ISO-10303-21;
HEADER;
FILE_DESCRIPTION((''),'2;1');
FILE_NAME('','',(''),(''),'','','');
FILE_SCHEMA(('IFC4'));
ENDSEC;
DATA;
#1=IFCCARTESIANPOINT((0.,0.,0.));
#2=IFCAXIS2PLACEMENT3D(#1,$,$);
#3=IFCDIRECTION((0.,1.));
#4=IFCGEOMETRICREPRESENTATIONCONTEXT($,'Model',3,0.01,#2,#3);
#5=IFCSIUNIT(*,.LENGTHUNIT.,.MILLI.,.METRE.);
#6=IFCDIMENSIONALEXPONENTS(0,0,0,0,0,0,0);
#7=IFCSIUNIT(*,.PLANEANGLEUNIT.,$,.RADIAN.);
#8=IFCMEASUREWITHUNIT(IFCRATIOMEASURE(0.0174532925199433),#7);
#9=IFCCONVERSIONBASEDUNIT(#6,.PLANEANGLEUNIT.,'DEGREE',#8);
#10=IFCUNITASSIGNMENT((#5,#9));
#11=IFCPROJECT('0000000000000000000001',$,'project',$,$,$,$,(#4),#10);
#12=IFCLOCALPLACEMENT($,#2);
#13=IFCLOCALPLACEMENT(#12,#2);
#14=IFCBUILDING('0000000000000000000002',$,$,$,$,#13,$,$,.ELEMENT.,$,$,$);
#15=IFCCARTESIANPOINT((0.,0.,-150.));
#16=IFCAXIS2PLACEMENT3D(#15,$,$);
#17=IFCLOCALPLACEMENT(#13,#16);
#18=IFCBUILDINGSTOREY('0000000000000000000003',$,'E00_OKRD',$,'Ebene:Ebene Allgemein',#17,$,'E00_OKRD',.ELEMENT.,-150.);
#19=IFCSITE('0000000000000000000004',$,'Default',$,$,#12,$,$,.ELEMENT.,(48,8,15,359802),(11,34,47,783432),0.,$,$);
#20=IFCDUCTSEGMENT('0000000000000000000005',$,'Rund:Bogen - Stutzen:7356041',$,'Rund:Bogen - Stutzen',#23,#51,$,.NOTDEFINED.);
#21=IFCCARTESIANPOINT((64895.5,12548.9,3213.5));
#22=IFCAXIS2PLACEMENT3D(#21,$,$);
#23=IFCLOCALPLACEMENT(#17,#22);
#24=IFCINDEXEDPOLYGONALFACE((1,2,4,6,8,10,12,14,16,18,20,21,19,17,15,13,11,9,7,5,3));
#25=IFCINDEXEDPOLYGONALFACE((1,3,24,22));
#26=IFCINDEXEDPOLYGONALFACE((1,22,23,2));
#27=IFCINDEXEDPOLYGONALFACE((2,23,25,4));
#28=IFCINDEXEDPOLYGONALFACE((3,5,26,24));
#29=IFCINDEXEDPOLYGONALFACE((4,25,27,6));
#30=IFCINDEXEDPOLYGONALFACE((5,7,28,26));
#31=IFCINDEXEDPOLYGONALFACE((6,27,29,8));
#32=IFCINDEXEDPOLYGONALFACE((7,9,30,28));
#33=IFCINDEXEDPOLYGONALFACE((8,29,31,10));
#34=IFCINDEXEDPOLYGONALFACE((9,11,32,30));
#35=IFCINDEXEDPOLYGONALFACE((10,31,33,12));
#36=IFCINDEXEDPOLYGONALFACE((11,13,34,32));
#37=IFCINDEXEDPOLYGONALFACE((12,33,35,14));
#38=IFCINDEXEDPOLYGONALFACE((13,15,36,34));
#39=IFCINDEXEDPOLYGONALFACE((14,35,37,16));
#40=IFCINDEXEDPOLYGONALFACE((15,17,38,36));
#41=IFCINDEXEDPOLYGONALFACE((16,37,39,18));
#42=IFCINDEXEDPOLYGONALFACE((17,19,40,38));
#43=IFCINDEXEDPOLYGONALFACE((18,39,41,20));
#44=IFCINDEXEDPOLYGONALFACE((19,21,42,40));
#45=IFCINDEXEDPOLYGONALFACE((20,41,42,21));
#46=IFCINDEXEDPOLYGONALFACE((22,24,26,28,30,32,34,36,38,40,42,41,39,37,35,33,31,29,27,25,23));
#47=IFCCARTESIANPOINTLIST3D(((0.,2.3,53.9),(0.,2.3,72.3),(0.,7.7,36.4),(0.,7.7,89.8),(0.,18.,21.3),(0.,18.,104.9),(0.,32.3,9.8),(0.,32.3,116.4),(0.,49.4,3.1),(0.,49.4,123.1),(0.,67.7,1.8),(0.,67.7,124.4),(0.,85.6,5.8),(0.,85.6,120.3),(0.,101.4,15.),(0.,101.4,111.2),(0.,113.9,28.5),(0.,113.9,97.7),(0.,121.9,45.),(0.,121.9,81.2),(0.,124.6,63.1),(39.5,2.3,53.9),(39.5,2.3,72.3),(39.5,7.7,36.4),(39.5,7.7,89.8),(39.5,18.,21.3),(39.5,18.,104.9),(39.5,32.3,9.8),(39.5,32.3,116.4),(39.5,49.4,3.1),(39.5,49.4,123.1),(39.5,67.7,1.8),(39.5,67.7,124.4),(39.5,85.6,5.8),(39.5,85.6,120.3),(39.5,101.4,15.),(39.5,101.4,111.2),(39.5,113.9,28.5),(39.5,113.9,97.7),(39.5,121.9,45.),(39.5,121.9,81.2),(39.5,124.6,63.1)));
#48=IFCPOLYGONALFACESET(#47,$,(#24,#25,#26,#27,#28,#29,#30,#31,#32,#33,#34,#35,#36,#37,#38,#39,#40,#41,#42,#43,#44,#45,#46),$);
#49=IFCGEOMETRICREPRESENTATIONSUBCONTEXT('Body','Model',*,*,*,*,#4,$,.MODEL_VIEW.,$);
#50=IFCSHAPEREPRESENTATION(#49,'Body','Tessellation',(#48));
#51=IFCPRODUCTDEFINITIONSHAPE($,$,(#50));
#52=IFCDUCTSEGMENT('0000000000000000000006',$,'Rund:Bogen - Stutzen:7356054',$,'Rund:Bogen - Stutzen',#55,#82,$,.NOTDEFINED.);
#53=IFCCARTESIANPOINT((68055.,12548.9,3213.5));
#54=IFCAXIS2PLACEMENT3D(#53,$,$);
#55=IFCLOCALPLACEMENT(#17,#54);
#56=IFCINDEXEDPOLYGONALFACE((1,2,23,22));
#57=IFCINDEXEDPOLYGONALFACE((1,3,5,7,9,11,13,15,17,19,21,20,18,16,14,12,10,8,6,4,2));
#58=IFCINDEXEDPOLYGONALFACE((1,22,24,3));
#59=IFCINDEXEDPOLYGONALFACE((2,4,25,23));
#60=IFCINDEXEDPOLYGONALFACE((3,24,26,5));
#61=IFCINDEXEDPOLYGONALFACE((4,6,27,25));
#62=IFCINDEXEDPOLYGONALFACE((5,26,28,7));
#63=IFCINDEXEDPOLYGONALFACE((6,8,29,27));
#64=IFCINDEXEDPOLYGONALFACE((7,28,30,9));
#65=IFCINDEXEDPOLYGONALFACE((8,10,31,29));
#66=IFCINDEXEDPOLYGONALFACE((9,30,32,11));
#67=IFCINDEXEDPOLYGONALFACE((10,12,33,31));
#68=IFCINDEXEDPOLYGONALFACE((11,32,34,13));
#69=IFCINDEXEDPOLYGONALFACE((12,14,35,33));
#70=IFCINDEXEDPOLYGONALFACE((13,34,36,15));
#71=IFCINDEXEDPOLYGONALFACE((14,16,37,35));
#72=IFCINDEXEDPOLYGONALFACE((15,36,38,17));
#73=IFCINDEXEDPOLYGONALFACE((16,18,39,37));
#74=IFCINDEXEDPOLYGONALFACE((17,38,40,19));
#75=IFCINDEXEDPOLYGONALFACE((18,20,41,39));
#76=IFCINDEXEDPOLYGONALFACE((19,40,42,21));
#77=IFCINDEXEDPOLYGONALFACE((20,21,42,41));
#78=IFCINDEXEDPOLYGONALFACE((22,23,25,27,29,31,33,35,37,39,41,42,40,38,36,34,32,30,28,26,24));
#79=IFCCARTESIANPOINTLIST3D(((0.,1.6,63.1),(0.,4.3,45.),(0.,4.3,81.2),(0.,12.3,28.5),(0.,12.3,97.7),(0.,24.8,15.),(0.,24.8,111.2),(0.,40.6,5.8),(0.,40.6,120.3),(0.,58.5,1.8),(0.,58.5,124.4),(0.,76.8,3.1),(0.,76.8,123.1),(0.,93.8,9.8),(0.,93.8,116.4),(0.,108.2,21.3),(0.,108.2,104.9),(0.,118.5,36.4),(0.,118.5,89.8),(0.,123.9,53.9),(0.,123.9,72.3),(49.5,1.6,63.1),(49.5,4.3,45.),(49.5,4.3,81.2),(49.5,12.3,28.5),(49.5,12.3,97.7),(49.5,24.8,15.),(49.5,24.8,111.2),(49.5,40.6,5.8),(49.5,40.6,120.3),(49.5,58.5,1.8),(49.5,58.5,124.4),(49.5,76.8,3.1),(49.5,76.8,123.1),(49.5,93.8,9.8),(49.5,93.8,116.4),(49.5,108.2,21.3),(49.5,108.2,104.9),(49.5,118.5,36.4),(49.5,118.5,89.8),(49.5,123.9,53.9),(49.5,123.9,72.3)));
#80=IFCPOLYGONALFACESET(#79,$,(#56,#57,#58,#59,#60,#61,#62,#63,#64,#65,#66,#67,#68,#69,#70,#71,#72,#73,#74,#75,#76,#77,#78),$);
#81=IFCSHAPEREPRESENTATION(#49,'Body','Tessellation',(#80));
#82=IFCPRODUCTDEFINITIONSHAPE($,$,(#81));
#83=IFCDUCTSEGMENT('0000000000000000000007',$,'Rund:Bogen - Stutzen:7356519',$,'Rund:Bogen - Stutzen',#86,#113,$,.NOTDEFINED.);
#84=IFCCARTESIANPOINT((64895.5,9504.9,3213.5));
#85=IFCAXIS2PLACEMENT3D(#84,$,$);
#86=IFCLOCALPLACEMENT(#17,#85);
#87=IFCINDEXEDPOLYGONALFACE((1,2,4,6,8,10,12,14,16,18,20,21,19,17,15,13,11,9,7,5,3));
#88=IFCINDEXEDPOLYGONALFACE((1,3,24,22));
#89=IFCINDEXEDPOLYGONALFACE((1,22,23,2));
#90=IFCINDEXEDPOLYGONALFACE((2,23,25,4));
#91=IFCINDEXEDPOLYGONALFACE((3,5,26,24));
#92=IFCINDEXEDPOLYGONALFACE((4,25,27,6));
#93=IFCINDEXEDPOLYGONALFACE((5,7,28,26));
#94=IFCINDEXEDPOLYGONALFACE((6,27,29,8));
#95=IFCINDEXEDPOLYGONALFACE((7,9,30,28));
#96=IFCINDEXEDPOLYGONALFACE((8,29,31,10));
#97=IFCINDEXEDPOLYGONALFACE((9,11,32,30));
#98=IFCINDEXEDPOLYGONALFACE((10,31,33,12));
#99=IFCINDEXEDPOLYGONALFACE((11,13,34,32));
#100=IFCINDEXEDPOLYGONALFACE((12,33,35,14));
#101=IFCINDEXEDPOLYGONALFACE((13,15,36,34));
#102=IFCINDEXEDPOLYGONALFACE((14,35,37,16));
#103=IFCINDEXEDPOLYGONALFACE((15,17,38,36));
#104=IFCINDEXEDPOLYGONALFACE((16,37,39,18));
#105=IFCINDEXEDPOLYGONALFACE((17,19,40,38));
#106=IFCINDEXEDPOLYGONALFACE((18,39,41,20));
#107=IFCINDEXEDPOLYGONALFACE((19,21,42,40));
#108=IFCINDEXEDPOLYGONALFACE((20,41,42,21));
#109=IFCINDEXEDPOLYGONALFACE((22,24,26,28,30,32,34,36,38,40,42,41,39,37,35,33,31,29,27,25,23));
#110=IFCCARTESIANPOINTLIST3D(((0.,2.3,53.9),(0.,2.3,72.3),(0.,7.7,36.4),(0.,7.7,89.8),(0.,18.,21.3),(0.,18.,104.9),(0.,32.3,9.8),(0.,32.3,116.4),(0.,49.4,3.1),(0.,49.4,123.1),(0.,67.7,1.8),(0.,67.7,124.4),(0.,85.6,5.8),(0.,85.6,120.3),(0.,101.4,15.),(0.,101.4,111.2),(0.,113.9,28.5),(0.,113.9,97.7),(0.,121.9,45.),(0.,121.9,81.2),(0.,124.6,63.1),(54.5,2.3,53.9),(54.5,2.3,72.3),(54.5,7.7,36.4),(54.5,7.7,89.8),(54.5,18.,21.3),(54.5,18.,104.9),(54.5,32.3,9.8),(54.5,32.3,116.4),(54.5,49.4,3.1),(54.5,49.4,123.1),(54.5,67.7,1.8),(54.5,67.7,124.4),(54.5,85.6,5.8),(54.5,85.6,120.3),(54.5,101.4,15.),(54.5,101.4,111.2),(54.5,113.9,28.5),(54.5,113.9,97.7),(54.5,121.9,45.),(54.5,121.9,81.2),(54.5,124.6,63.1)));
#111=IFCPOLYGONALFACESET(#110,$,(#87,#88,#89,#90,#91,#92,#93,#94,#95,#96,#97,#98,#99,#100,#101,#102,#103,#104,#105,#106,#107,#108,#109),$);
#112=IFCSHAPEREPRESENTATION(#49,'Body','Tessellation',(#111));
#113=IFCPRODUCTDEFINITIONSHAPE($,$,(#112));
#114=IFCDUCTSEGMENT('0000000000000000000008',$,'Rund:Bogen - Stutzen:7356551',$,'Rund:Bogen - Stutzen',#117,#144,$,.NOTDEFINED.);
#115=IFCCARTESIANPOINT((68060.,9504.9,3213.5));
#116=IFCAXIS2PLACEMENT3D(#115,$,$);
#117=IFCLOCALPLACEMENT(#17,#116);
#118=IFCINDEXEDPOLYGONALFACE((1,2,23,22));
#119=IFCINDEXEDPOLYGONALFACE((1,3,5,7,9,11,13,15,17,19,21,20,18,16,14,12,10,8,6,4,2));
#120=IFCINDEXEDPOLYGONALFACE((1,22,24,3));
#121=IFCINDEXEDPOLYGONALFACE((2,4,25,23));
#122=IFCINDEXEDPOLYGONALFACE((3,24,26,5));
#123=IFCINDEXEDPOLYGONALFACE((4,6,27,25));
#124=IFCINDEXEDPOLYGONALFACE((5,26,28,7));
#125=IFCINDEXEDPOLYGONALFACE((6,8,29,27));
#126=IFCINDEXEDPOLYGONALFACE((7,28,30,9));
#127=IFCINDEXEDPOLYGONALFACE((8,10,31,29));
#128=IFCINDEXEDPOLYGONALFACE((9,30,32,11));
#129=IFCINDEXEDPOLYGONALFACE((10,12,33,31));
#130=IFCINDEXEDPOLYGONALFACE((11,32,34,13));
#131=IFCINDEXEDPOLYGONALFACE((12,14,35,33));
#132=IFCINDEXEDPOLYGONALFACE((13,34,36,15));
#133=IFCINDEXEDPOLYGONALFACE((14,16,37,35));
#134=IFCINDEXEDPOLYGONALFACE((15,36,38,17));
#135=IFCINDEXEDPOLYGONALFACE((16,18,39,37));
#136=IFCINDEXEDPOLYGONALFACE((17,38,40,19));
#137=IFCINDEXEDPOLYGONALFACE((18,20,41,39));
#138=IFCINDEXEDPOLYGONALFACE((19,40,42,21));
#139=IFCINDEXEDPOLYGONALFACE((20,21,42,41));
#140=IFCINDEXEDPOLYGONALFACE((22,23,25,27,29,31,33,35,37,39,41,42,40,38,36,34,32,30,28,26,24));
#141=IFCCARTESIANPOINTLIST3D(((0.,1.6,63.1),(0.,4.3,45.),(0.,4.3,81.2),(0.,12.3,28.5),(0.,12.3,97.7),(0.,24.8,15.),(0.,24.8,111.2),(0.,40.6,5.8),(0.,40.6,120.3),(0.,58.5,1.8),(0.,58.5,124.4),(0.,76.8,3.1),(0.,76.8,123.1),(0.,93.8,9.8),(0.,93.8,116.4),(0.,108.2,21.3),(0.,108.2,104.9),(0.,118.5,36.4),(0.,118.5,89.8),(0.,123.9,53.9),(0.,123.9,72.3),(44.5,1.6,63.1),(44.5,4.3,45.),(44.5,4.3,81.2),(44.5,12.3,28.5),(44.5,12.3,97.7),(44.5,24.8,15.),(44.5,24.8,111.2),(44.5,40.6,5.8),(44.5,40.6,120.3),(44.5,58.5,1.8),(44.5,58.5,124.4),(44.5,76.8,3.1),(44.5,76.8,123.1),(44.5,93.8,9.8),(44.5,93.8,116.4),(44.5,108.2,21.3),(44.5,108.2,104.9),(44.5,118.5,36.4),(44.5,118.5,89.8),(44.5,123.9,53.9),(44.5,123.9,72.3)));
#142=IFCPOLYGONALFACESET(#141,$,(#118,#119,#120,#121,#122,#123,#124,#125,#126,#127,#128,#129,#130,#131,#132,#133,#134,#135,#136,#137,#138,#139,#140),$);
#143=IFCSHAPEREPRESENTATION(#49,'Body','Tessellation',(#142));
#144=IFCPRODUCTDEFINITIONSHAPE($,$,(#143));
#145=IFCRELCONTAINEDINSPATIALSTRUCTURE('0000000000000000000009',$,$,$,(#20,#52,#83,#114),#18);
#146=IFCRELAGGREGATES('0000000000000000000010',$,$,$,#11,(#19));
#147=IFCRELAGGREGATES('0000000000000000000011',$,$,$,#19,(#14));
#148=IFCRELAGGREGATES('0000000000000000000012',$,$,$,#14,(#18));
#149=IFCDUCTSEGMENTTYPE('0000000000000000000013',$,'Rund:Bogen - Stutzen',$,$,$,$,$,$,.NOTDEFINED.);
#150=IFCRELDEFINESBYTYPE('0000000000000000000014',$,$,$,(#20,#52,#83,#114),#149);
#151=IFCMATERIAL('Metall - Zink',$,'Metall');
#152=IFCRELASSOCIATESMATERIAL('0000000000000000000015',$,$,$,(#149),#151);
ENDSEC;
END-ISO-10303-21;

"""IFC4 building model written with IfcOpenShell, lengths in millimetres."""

from ifc_helpers import new_model, entity, si_unit, converted_unit, direction, frame, frame_2d, origin, origin_2d_with_axis, place, context, subcontext, project, spatial, circle, extrude, material, type_object, element, save


model = new_model("IFC4")

# Units and contexts
model_context = context("Model", 3, precision=0.01, world=origin(), true_north=direction((0.0, 1.0)))
body_context = subcontext(model_context, "Body", "Model", "MODEL_VIEW")
ifc_project = project(units=[si_unit("LENGTHUNIT", "METRE", prefix="MILLI"), converted_unit("PLANEANGLEUNIT", "DEGREE", entity("IfcRatioMeasure", 0.0174532925199433), si_unit("PLANEANGLEUNIT", "RADIAN"), dimensions=[0, 0, 0, 0, 0, 0, 0])], contexts=[model_context])

# Site, building, storey
site_placement = place(None, origin())
site = spatial("IfcSite", under=ifc_project, at=site_placement, Name="Default", CompositionType="ELEMENT", RefLatitude=(48, 8, 15, 359802), RefLongitude=(11, 34, 47, 783432), RefElevation=0.0)
building_placement = place(site_placement, origin())
building = spatial("IfcBuilding", under=site, at=building_placement, CompositionType="ELEMENT")
storey_placement = place(building_placement, frame((0.0, 0.0, -150.0)))
storey = spatial("IfcBuildingStorey", under=building, at=storey_placement, Name="E00_OKRD", ObjectType="Ebene:Ebene Allgemein", LongName="E00_OKRD", CompositionType="ELEMENT", Elevation=-150.0)

# Duct segments
ifc_material_1 = material(Name="Metall - Zink", Category="Metall")
duct_segment_type_1 = type_object("IfcDuctSegmentType", Name="Rund:Bogen - Stutzen", PredefinedType="NOTDEFINED", material=ifc_material_1)
duct_segment_1_placement = place(storey_placement, frame((64895.5, 12548.9, 3213.5)))
element("IfcDuctSegment", 1, at=duct_segment_1_placement, inside=storey, type_object=duct_segment_type_1, Name="Rund:Bogen - Stutzen:7356041", ObjectType="Rund:Bogen - Stutzen", PredefinedType="NOTDEFINED", context=body_context, shape_type="SweptSolid", body=[
    extrude(circle(Radius=61.5, at=origin_2d_with_axis()), frame((0.0, 63.1, 63.1), z_axis=(1.0, 0.0, 0.0), x_axis=(0.0, 1.0, 0.0)), (0.0, 0.0, 1.0), 39.5),
])
duct_segment_2_placement = place(storey_placement, frame((68055.0, 12548.9, 3213.5)))
element("IfcDuctSegment", 2, at=duct_segment_2_placement, inside=storey, type_object=duct_segment_type_1, Name="Rund:Bogen - Stutzen:7356054", ObjectType="Rund:Bogen - Stutzen", PredefinedType="NOTDEFINED", context=body_context, shape_type="SweptSolid", body=[
    extrude(circle(Radius=61.5, at=origin_2d_with_axis()), frame((0.0, 63.1, 63.1), z_axis=(1.0, 0.0, 0.0), x_axis=(0.0, -1.0, 0.0)), (0.0, 0.0, 1.0), 49.5),
])
duct_segment_3_placement = place(storey_placement, frame((64895.5, 9504.9, 3213.5)))
element("IfcDuctSegment", 3, at=duct_segment_3_placement, inside=storey, type_object=duct_segment_type_1, Name="Rund:Bogen - Stutzen:7356519", ObjectType="Rund:Bogen - Stutzen", PredefinedType="NOTDEFINED", context=body_context, shape_type="SweptSolid", body=[
    extrude(circle(Radius=61.5, at=frame_2d((0.0, 0.0), x_axis=(1.0, 0.0))), frame((0.0, 63.1, 63.1), z_axis=(1.0, 0.0, 0.0), x_axis=(0.0, 1.0, 0.0)), (0.0, 0.0, 1.0), 54.5),
])
duct_segment_4_placement = place(storey_placement, frame((68060.0, 9504.9, 3213.5)))
element("IfcDuctSegment", 4, at=duct_segment_4_placement, inside=storey, type_object=duct_segment_type_1, Name="Rund:Bogen - Stutzen:7356551", ObjectType="Rund:Bogen - Stutzen", PredefinedType="NOTDEFINED", context=body_context, shape_type="SweptSolid", body=[
    extrude(circle(Radius=61.5, at=origin_2d_with_axis()), frame((0.0, 63.1, 63.1), z_axis=(1.0, 0.0, 0.0), x_axis=(0.0, -1.0, 0.0)), (0.0, 0.0, 1.0), 44.5),
])

save(model, "model.ifc")
